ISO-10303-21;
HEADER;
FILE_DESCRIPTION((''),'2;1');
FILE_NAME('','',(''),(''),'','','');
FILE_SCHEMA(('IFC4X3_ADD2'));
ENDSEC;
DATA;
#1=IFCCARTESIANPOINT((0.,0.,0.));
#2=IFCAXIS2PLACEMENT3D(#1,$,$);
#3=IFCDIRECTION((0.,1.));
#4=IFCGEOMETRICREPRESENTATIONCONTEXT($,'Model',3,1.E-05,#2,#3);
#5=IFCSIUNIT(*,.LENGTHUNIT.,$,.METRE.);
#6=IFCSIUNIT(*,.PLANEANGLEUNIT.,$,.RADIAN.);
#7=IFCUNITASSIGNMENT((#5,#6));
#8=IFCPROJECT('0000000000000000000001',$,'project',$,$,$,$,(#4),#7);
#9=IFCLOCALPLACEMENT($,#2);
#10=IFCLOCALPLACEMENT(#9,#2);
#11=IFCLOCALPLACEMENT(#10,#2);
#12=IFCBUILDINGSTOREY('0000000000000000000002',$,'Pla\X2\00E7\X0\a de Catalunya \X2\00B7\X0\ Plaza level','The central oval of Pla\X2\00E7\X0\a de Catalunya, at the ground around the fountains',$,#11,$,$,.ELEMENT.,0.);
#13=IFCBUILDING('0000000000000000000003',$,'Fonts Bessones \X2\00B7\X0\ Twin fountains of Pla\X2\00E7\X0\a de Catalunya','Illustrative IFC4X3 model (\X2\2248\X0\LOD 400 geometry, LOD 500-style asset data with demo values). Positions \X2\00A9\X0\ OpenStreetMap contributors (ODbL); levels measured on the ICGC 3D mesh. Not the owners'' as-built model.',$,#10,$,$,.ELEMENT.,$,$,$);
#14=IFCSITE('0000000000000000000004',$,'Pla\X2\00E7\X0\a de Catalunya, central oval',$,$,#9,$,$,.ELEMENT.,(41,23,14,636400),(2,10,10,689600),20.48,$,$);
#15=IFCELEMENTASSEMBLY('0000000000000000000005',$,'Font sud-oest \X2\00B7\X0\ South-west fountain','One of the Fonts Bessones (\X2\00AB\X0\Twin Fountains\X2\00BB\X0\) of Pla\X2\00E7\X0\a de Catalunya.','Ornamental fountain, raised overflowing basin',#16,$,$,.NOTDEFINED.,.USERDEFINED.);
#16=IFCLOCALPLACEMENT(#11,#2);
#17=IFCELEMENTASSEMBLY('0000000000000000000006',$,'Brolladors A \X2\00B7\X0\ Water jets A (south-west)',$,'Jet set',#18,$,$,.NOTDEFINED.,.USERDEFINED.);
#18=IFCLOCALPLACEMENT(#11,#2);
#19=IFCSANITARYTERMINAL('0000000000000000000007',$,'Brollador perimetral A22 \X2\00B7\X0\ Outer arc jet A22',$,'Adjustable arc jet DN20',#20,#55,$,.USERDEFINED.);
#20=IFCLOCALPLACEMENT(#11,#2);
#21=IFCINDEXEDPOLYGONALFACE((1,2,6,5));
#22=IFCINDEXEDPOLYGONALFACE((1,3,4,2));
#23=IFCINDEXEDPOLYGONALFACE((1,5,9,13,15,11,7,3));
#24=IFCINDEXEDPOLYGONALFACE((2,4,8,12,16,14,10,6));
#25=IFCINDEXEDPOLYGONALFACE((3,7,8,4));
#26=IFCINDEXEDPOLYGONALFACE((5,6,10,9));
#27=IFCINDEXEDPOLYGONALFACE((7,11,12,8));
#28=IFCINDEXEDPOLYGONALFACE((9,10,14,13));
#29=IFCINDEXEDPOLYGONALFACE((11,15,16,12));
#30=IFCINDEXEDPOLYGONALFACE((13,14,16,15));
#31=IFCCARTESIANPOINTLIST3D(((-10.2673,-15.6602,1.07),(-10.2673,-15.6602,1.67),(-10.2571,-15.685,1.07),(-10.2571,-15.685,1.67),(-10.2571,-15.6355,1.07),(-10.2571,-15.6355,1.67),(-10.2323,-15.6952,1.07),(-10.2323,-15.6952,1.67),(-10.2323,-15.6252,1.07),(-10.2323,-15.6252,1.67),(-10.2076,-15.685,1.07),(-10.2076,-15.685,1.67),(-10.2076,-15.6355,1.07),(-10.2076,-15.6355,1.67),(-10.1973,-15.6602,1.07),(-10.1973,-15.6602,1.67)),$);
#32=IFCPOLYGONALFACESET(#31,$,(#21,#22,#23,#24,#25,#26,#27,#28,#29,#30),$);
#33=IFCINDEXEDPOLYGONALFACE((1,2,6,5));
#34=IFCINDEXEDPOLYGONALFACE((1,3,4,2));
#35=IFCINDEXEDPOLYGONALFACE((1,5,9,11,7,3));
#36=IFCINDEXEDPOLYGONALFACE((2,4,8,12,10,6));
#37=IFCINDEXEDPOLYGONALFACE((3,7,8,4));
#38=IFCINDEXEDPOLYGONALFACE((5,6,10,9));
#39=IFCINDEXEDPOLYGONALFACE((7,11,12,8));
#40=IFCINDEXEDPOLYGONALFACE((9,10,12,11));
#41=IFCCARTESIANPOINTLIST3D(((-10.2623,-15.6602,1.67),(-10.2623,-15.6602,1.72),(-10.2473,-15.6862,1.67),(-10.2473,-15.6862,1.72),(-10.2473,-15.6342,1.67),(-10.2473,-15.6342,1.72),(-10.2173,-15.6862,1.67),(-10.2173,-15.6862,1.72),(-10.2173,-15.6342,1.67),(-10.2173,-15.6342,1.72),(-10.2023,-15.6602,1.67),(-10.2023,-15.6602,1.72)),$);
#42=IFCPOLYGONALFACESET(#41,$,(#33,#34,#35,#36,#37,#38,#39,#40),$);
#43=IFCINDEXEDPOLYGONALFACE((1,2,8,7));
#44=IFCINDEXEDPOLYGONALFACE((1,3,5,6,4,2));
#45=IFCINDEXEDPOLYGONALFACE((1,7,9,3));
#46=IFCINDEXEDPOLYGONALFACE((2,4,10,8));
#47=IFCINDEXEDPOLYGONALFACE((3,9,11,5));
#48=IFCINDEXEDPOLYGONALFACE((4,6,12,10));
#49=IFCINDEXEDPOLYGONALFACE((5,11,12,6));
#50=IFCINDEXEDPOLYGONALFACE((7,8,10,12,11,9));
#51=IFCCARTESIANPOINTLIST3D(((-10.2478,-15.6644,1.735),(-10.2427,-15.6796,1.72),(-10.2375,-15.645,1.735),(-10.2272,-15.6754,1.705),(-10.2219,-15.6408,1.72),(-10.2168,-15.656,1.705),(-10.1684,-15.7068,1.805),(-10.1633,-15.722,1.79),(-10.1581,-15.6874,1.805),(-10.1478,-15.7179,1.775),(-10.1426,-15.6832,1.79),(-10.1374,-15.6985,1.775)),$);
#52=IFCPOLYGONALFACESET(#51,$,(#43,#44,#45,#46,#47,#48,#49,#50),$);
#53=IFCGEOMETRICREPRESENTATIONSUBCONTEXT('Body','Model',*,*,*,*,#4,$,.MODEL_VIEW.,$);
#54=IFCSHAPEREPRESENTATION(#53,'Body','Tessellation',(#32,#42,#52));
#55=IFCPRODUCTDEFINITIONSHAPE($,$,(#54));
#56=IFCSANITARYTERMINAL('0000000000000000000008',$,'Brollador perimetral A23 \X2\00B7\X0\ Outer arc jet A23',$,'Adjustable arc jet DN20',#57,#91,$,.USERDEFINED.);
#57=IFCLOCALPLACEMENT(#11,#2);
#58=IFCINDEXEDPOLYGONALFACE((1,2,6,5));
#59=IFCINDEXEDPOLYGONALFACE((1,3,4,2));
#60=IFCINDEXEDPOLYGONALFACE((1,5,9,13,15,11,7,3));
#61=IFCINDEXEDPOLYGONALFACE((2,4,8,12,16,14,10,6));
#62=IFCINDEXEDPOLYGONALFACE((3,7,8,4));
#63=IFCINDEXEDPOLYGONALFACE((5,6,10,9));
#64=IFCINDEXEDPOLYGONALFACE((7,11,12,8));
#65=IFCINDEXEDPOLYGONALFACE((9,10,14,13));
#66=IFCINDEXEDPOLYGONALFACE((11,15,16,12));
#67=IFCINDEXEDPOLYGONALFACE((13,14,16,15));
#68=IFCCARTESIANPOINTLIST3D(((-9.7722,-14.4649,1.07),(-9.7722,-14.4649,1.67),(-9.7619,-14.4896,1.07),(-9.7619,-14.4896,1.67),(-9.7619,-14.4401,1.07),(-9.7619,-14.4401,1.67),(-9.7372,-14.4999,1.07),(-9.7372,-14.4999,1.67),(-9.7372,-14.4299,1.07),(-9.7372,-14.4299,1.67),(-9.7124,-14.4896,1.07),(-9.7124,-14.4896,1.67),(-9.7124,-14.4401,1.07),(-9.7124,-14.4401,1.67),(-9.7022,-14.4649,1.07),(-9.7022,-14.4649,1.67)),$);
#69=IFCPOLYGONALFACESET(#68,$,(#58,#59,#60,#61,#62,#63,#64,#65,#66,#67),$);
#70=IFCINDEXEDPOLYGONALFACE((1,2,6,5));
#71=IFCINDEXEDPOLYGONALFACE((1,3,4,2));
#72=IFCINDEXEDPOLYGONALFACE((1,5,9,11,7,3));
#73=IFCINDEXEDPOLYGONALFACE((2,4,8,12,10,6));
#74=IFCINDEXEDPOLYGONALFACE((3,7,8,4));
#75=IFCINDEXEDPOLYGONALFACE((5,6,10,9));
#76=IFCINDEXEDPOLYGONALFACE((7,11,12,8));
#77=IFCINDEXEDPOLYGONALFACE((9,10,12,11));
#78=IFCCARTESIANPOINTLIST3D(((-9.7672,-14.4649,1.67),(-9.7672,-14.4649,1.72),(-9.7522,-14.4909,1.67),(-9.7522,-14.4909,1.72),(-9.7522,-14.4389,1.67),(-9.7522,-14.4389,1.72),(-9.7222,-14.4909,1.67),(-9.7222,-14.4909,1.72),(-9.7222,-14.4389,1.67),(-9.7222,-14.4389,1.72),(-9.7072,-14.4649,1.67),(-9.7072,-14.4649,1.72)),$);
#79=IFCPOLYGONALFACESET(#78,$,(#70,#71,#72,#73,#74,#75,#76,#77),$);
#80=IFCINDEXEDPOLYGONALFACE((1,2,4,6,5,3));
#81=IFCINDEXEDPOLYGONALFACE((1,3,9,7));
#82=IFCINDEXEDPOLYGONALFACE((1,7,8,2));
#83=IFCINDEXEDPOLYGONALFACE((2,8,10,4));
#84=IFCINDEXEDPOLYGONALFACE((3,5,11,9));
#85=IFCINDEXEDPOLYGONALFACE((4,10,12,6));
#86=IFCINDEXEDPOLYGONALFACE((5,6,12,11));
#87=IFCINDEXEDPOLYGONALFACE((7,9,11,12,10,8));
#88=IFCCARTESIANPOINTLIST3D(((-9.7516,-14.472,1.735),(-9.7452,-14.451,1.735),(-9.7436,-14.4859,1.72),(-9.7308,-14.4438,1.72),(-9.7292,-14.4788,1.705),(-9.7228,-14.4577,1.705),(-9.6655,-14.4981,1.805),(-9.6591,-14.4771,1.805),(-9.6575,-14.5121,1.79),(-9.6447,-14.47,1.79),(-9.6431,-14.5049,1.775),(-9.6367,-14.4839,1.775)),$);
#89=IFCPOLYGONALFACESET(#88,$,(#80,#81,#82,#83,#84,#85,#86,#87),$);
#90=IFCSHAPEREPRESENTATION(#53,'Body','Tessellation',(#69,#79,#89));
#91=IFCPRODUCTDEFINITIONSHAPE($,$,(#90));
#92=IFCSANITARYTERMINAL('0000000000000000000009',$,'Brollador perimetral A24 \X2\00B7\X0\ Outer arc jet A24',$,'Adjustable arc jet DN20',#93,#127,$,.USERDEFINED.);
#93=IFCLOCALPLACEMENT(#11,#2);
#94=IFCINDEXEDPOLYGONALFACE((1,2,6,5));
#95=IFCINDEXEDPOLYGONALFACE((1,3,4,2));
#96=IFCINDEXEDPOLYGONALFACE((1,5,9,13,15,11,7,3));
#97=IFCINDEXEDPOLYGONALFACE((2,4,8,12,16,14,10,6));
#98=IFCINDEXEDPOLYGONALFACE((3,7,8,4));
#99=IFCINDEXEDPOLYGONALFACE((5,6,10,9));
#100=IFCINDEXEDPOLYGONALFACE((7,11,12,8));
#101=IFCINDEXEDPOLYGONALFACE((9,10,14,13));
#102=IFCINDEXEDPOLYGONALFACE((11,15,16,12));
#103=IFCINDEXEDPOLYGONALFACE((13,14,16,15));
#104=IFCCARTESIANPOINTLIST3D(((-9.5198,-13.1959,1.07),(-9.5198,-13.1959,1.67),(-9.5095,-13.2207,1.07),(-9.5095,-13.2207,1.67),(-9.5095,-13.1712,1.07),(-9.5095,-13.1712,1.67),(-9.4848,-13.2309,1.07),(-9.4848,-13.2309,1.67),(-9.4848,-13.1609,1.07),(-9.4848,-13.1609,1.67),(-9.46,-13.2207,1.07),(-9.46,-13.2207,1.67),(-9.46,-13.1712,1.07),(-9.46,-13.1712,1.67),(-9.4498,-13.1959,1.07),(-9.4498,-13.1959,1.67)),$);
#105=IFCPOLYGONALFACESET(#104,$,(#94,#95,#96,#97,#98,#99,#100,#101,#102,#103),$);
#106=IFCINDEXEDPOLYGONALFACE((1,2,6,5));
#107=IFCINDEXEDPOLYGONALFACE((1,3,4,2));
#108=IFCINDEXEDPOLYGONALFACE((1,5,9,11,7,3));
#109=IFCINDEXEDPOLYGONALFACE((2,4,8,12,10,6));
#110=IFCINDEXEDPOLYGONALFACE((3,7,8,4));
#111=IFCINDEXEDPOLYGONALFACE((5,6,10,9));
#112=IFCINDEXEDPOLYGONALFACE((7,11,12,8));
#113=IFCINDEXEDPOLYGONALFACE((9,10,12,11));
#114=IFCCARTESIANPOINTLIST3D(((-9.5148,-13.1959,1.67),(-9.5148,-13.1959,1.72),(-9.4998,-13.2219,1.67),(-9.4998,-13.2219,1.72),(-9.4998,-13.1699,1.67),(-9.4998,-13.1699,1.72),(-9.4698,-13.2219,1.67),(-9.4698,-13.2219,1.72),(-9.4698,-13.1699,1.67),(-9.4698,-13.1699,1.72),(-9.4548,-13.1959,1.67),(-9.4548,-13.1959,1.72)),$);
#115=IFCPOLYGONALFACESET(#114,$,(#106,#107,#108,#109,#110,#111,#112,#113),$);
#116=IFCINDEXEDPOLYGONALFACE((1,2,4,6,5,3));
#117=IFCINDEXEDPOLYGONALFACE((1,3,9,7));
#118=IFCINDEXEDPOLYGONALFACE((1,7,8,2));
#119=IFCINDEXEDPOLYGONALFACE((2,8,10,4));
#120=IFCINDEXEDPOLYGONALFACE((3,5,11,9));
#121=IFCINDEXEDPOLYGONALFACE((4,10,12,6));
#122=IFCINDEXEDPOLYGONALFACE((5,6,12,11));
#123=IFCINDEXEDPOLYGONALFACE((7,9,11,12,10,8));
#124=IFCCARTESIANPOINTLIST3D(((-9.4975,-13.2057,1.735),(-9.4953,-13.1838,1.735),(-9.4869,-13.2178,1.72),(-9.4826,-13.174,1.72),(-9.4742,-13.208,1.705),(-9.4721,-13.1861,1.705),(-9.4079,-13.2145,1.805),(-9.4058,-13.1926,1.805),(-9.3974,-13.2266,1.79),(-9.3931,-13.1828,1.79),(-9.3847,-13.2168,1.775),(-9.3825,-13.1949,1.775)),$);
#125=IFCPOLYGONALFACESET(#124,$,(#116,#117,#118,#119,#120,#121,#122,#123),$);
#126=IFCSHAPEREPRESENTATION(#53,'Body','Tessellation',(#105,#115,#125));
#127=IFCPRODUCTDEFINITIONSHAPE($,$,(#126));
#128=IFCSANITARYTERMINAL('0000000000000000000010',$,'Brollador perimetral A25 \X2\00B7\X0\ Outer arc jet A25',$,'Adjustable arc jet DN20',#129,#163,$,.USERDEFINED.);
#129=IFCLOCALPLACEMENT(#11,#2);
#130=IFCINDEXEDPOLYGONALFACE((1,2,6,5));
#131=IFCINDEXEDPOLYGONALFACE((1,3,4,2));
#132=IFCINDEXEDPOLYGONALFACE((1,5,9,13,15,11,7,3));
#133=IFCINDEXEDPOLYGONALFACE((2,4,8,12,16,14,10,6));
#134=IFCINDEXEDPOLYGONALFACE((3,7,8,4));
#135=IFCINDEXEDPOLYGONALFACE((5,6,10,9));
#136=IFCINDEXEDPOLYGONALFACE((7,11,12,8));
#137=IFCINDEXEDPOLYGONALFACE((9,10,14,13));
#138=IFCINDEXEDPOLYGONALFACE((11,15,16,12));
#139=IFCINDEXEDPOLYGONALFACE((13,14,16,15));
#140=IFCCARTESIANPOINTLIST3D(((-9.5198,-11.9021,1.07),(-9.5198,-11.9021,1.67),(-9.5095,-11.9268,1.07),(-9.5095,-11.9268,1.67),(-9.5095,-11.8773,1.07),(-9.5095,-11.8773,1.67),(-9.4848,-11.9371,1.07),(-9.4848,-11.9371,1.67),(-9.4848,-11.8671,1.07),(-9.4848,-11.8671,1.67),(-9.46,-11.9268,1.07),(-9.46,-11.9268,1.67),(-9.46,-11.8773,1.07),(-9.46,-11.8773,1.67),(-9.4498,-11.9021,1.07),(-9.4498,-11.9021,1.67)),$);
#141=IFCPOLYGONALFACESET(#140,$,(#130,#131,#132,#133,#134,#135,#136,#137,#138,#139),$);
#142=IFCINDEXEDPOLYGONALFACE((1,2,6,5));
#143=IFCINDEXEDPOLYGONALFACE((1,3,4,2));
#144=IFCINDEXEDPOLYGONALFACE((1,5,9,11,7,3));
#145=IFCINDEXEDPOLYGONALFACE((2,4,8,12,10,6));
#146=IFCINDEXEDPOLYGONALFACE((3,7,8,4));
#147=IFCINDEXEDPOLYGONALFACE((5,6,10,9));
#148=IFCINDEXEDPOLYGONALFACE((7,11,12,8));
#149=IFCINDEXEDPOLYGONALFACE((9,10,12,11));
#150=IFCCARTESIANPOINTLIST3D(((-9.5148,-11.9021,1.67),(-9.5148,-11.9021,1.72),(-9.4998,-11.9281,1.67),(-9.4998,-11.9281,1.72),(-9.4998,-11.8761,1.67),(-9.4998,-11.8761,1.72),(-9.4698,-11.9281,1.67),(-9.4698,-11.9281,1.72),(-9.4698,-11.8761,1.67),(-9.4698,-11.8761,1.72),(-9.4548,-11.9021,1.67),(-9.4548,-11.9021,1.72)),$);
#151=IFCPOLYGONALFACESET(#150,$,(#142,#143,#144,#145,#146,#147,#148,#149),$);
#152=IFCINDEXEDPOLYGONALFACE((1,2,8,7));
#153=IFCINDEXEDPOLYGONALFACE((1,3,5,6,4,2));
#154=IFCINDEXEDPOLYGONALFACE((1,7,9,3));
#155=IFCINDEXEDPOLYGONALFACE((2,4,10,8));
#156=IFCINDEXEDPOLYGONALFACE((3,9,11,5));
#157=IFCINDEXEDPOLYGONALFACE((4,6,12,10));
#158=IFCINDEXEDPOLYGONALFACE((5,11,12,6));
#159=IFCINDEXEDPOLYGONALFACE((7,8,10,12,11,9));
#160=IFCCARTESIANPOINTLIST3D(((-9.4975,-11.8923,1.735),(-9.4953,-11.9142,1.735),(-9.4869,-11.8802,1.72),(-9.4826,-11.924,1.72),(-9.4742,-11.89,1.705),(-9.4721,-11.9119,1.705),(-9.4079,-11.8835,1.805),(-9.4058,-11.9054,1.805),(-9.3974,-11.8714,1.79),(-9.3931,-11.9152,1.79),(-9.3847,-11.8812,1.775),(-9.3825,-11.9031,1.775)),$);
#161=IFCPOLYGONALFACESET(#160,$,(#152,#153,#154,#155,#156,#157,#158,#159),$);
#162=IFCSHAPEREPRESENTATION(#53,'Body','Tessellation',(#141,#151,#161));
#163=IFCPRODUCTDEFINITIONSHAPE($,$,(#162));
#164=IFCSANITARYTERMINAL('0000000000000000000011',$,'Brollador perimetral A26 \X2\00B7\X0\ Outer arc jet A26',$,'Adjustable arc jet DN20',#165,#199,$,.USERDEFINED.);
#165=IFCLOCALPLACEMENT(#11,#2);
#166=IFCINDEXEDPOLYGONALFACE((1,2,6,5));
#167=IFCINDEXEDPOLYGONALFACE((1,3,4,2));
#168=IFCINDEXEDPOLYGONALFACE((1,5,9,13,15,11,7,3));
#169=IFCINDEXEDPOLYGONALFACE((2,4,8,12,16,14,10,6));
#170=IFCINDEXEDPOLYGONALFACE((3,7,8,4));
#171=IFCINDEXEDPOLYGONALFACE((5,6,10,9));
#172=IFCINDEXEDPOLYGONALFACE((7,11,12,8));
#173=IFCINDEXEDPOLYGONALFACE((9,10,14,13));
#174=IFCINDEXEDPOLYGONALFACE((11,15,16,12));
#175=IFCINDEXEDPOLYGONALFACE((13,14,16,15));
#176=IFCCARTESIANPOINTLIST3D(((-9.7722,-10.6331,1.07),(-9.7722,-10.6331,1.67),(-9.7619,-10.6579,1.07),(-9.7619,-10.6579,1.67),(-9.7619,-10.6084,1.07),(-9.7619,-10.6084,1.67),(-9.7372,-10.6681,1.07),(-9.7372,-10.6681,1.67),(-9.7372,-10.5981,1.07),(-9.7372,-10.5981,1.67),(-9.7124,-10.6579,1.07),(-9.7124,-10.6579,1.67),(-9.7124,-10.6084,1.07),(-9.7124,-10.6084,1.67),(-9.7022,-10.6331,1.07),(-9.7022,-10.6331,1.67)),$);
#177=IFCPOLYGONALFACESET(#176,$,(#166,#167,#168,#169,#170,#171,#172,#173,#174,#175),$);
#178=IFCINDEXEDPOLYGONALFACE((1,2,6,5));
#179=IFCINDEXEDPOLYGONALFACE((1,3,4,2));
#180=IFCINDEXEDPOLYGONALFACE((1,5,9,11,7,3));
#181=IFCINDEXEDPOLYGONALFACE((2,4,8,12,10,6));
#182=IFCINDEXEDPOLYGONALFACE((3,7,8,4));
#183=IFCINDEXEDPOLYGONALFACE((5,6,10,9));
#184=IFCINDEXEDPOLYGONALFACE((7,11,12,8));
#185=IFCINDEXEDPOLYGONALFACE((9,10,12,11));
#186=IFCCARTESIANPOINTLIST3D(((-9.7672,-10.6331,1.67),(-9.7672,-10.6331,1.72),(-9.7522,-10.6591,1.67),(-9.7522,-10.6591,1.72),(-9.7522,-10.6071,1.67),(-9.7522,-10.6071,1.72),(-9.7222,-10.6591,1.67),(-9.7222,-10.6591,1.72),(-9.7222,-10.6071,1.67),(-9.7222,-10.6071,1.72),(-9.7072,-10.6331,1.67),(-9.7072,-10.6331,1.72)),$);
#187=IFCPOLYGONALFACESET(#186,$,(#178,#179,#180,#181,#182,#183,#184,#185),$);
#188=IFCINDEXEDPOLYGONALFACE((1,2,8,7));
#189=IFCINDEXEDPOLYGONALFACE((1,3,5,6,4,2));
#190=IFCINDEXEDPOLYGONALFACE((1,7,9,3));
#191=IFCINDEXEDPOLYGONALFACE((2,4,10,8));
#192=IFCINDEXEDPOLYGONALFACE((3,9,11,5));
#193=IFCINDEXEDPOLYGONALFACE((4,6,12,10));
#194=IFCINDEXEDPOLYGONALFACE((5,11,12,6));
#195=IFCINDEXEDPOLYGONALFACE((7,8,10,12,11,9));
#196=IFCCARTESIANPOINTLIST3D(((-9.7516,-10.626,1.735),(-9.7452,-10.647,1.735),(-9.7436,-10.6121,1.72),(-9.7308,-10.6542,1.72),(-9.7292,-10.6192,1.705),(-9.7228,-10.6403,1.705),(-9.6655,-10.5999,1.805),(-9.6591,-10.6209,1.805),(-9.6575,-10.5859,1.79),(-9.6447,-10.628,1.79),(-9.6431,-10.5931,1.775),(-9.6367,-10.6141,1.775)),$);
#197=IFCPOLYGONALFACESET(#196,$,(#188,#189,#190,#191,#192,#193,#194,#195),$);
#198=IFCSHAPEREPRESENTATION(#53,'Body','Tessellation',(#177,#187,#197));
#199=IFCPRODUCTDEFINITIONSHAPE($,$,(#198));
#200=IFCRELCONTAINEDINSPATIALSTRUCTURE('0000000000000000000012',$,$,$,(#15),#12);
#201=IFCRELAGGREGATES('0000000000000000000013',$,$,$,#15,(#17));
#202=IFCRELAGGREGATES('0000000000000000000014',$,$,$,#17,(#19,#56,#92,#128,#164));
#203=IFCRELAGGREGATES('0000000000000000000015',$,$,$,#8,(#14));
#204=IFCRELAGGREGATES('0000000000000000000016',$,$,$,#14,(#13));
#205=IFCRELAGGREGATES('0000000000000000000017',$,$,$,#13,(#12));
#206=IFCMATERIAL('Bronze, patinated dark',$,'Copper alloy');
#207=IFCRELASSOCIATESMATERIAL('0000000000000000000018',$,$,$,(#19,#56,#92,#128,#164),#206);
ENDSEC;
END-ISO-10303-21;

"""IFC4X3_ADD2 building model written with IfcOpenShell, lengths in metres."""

from ifc_helpers import new_model, si_unit, direction, frame, origin, place, context, subcontext, project, spatial, polyline, outline, extrude, material, element, aggregate, save


model = new_model("IFC4X3_ADD2")

# Units and contexts
model_context = context("Model", 3, precision=1e-05, world=origin(), true_north=direction((0.0, 1.0)))
body_context = subcontext(model_context, "Body", "Model", "MODEL_VIEW")
ifc_project = project(units=[si_unit("LENGTHUNIT", "METRE"), si_unit("PLANEANGLEUNIT", "RADIAN")], contexts=[model_context])

# Site, building, storey
site_placement = place(None, origin())
site = spatial("IfcSite", under=ifc_project, at=site_placement, Name="Plaça de Catalunya, central oval", CompositionType="ELEMENT", RefLatitude=(41, 23, 14, 636400), RefLongitude=(2, 10, 10, 689600), RefElevation=20.48)
building_placement = place(site_placement, origin())
building = spatial("IfcBuilding", under=site, at=building_placement, Name="Fonts Bessones · Twin fountains of Plaça de Catalunya", Description="Illustrative IFC4X3 model (≈LOD 400 geometry, LOD 500-style asset data with demo values). Positions © OpenStreetMap contributors (ODbL); levels measured on the ICGC 3D mesh. Not the owners' as-built model.", CompositionType="ELEMENT")
storey_placement = place(building_placement, origin())
storey = spatial("IfcBuildingStorey", under=building, at=storey_placement, Name="Plaça de Catalunya · Plaza level", Description="The central oval of Plaça de Catalunya, at the ground around the fountains", CompositionType="ELEMENT", Elevation=0.0)

# Element assemblies, sanitary terminals
assembly_1_placement = place(building_placement, origin())
assembly_1 = element("IfcElementAssembly", 1, at=assembly_1_placement, inside=storey, Name="Font sud-oest · South-west fountain", Description="One of the Fonts Bessones («Twin Fountains») of Plaça de Catalunya.", ObjectType="Ornamental fountain, raised overflowing basin", AssemblyPlace="NOTDEFINED", PredefinedType="USERDEFINED")
assembly_2_placement = place(building_placement, origin())
assembly_2 = element("IfcElementAssembly", 2, at=assembly_2_placement, Name="Brolladors A · Water jets A (south-west)", ObjectType="Jet set", AssemblyPlace="NOTDEFINED", PredefinedType="USERDEFINED")
aggregate(assembly_1, [assembly_2])
ifc_material = material(Name="Bronze, patinated dark", Category="Copper alloy")
sanitary_terminal_1_placement = place(building_placement, origin())
sanitary_terminal_1 = element("IfcSanitaryTerminal", 3, at=sanitary_terminal_1_placement, material=ifc_material, Name="Brollador perimetral A22 · Outer arc jet A22", ObjectType="Adjustable arc jet DN20", PredefinedType="USERDEFINED", context=body_context, shape_type="SweptSolid", body=[
    extrude(outline(polyline([(-10.1973, -15.6602), (-10.2076, -15.6355), (-10.2323, -15.6252), (-10.2571, -15.6355), (-10.2673, -15.6602), (-10.2571, -15.685), (-10.2323, -15.6952), (-10.2076, -15.685), (-10.1973, -15.6602)])), frame((0.0, 0.0, 1.07)), (0.0, 0.0, 1.0), 0.6),
    extrude(outline(polyline([(-10.2023, -15.6602), (-10.2173, -15.6342), (-10.2473, -15.6342), (-10.2623, -15.6602), (-10.2473, -15.6862), (-10.2173, -15.6862), (-10.2023, -15.6602)])), frame((0.0, 0.0, 1.67)), (0.0, 0.0, 1.0), 0.05),
    extrude(outline(polyline([(0.022, 0.0), (0.011, 0.0191), (-0.011, 0.0191), (-0.022, 0.0), (-0.011, -0.0191), (0.011, -0.0191), (0.022, 0.0)])), frame((-10.2323, -15.6602, 1.72), z_axis=(0.696147, -0.372098, 0.613941), x_axis=(-0.471397, -0.881921, 0.0)), (0.0, 0.0, 1.0), 0.114),
])
sanitary_terminal_2_placement = place(building_placement, origin())
sanitary_terminal_2 = element("IfcSanitaryTerminal", 4, at=sanitary_terminal_2_placement, material=ifc_material, Name="Brollador perimetral A23 · Outer arc jet A23", ObjectType="Adjustable arc jet DN20", PredefinedType="USERDEFINED", context=body_context, shape_type="SweptSolid", body=[
    extrude(outline(polyline([(-9.7022, -14.4649), (-9.7124, -14.4401), (-9.7372, -14.4299), (-9.7619, -14.4401), (-9.7722, -14.4649), (-9.7619, -14.4896), (-9.7372, -14.4999), (-9.7124, -14.4896), (-9.7022, -14.4649)])), frame((0.0, 0.0, 1.07)), (0.0, 0.0, 1.0), 0.6),
    extrude(outline(polyline([(-9.7072, -14.4649), (-9.7222, -14.4389), (-9.7522, -14.4389), (-9.7672, -14.4649), (-9.7522, -14.4909), (-9.7222, -14.4909), (-9.7072, -14.4649)])), frame((0.0, 0.0, 1.67)), (0.0, 0.0, 1.0), 0.05),
    extrude(outline(polyline([(0.022, 0.0), (0.011, 0.0191), (-0.011, 0.0191), (-0.022, 0.0), (-0.011, -0.0191), (0.011, -0.0191), (0.022, 0.0)])), frame((-9.7372, -14.4649, 1.72), z_axis=(0.755363, -0.229137, 0.613941), x_axis=(-0.290285, -0.95694, 0.0)), (0.0, 0.0, 1.0), 0.114),
])
sanitary_terminal_3_placement = place(building_placement, origin())
sanitary_terminal_3 = element("IfcSanitaryTerminal", 5, at=sanitary_terminal_3_placement, material=ifc_material, Name="Brollador perimetral A24 · Outer arc jet A24", ObjectType="Adjustable arc jet DN20", PredefinedType="USERDEFINED", context=body_context, shape_type="SweptSolid", body=[
    extrude(outline(polyline([(-9.4498, -13.1959), (-9.46, -13.1712), (-9.4848, -13.1609), (-9.5095, -13.1712), (-9.5198, -13.1959), (-9.5095, -13.2207), (-9.4848, -13.2309), (-9.46, -13.2207), (-9.4498, -13.1959)])), frame((0.0, 0.0, 1.07)), (0.0, 0.0, 1.0), 0.6),
    extrude(outline(polyline([(-9.4548, -13.1959), (-9.4698, -13.1699), (-9.4998, -13.1699), (-9.5148, -13.1959), (-9.4998, -13.2219), (-9.4698, -13.2219), (-9.4548, -13.1959)])), frame((0.0, 0.0, 1.67)), (0.0, 0.0, 1.0), 0.05),
    extrude(outline(polyline([(0.022, 0.0), (0.011, 0.0191), (-0.011, 0.0191), (-0.022, 0.0), (-0.011, -0.0191), (0.011, -0.0191), (0.022, 0.0)])), frame((-9.4848, -13.1959, 1.72), z_axis=(0.785551, -0.07737, 0.613941), x_axis=(-0.098017, -0.995185, 0.0)), (0.0, 0.0, 1.0), 0.114),
])
sanitary_terminal_4_placement = place(building_placement, origin())
sanitary_terminal_4 = element("IfcSanitaryTerminal", 6, at=sanitary_terminal_4_placement, material=ifc_material, Name="Brollador perimetral A25 · Outer arc jet A25", ObjectType="Adjustable arc jet DN20", PredefinedType="USERDEFINED", context=body_context, shape_type="SweptSolid", body=[
    extrude(outline(polyline([(-9.4498, -11.9021), (-9.46, -11.8773), (-9.4848, -11.8671), (-9.5095, -11.8773), (-9.5198, -11.9021), (-9.5095, -11.9268), (-9.4848, -11.9371), (-9.46, -11.9268), (-9.4498, -11.9021)])), frame((0.0, 0.0, 1.07)), (0.0, 0.0, 1.0), 0.6),
    extrude(outline(polyline([(-9.4548, -11.9021), (-9.4698, -11.8761), (-9.4998, -11.8761), (-9.5148, -11.9021), (-9.4998, -11.9281), (-9.4698, -11.9281), (-9.4548, -11.9021)])), frame((0.0, 0.0, 1.67)), (0.0, 0.0, 1.0), 0.05),
    extrude(outline(polyline([(0.022, 0.0), (0.011, 0.0191), (-0.011, 0.0191), (-0.022, 0.0), (-0.011, -0.0191), (0.011, -0.0191), (0.022, 0.0)])), frame((-9.4848, -11.9021, 1.72), z_axis=(0.785551, 0.07737, 0.613941), x_axis=(0.098017, -0.995185, 0.0)), (0.0, 0.0, 1.0), 0.114),
])
sanitary_terminal_5_placement = place(building_placement, origin())
sanitary_terminal_5 = element("IfcSanitaryTerminal", 7, at=sanitary_terminal_5_placement, material=ifc_material, Name="Brollador perimetral A26 · Outer arc jet A26", ObjectType="Adjustable arc jet DN20", PredefinedType="USERDEFINED", context=body_context, shape_type="SweptSolid", body=[
    extrude(outline(polyline([(-9.7022, -10.6331), (-9.7124, -10.6084), (-9.7372, -10.5981), (-9.7619, -10.6084), (-9.7722, -10.6331), (-9.7619, -10.6579), (-9.7372, -10.6681), (-9.7124, -10.6579), (-9.7022, -10.6331)])), frame((0.0, 0.0, 1.07)), (0.0, 0.0, 1.0), 0.6),
    extrude(outline(polyline([(-9.7072, -10.6331), (-9.7222, -10.6071), (-9.7522, -10.6071), (-9.7672, -10.6331), (-9.7522, -10.6591), (-9.7222, -10.6591), (-9.7072, -10.6331)])), frame((0.0, 0.0, 1.67)), (0.0, 0.0, 1.0), 0.05),
    extrude(outline(polyline([(0.022, 0.0), (0.011, 0.0191), (-0.011, 0.0191), (-0.022, 0.0), (-0.011, -0.0191), (0.011, -0.0191), (0.022, 0.0)])), frame((-9.7372, -10.6331, 1.72), z_axis=(0.755363, 0.229137, 0.613941), x_axis=(0.290285, -0.95694, 0.0)), (0.0, 0.0, 1.0), 0.114),
])
aggregate(assembly_2, [sanitary_terminal_1, sanitary_terminal_2, sanitary_terminal_3, sanitary_terminal_4, sanitary_terminal_5])

save(model, "model.ifc")
